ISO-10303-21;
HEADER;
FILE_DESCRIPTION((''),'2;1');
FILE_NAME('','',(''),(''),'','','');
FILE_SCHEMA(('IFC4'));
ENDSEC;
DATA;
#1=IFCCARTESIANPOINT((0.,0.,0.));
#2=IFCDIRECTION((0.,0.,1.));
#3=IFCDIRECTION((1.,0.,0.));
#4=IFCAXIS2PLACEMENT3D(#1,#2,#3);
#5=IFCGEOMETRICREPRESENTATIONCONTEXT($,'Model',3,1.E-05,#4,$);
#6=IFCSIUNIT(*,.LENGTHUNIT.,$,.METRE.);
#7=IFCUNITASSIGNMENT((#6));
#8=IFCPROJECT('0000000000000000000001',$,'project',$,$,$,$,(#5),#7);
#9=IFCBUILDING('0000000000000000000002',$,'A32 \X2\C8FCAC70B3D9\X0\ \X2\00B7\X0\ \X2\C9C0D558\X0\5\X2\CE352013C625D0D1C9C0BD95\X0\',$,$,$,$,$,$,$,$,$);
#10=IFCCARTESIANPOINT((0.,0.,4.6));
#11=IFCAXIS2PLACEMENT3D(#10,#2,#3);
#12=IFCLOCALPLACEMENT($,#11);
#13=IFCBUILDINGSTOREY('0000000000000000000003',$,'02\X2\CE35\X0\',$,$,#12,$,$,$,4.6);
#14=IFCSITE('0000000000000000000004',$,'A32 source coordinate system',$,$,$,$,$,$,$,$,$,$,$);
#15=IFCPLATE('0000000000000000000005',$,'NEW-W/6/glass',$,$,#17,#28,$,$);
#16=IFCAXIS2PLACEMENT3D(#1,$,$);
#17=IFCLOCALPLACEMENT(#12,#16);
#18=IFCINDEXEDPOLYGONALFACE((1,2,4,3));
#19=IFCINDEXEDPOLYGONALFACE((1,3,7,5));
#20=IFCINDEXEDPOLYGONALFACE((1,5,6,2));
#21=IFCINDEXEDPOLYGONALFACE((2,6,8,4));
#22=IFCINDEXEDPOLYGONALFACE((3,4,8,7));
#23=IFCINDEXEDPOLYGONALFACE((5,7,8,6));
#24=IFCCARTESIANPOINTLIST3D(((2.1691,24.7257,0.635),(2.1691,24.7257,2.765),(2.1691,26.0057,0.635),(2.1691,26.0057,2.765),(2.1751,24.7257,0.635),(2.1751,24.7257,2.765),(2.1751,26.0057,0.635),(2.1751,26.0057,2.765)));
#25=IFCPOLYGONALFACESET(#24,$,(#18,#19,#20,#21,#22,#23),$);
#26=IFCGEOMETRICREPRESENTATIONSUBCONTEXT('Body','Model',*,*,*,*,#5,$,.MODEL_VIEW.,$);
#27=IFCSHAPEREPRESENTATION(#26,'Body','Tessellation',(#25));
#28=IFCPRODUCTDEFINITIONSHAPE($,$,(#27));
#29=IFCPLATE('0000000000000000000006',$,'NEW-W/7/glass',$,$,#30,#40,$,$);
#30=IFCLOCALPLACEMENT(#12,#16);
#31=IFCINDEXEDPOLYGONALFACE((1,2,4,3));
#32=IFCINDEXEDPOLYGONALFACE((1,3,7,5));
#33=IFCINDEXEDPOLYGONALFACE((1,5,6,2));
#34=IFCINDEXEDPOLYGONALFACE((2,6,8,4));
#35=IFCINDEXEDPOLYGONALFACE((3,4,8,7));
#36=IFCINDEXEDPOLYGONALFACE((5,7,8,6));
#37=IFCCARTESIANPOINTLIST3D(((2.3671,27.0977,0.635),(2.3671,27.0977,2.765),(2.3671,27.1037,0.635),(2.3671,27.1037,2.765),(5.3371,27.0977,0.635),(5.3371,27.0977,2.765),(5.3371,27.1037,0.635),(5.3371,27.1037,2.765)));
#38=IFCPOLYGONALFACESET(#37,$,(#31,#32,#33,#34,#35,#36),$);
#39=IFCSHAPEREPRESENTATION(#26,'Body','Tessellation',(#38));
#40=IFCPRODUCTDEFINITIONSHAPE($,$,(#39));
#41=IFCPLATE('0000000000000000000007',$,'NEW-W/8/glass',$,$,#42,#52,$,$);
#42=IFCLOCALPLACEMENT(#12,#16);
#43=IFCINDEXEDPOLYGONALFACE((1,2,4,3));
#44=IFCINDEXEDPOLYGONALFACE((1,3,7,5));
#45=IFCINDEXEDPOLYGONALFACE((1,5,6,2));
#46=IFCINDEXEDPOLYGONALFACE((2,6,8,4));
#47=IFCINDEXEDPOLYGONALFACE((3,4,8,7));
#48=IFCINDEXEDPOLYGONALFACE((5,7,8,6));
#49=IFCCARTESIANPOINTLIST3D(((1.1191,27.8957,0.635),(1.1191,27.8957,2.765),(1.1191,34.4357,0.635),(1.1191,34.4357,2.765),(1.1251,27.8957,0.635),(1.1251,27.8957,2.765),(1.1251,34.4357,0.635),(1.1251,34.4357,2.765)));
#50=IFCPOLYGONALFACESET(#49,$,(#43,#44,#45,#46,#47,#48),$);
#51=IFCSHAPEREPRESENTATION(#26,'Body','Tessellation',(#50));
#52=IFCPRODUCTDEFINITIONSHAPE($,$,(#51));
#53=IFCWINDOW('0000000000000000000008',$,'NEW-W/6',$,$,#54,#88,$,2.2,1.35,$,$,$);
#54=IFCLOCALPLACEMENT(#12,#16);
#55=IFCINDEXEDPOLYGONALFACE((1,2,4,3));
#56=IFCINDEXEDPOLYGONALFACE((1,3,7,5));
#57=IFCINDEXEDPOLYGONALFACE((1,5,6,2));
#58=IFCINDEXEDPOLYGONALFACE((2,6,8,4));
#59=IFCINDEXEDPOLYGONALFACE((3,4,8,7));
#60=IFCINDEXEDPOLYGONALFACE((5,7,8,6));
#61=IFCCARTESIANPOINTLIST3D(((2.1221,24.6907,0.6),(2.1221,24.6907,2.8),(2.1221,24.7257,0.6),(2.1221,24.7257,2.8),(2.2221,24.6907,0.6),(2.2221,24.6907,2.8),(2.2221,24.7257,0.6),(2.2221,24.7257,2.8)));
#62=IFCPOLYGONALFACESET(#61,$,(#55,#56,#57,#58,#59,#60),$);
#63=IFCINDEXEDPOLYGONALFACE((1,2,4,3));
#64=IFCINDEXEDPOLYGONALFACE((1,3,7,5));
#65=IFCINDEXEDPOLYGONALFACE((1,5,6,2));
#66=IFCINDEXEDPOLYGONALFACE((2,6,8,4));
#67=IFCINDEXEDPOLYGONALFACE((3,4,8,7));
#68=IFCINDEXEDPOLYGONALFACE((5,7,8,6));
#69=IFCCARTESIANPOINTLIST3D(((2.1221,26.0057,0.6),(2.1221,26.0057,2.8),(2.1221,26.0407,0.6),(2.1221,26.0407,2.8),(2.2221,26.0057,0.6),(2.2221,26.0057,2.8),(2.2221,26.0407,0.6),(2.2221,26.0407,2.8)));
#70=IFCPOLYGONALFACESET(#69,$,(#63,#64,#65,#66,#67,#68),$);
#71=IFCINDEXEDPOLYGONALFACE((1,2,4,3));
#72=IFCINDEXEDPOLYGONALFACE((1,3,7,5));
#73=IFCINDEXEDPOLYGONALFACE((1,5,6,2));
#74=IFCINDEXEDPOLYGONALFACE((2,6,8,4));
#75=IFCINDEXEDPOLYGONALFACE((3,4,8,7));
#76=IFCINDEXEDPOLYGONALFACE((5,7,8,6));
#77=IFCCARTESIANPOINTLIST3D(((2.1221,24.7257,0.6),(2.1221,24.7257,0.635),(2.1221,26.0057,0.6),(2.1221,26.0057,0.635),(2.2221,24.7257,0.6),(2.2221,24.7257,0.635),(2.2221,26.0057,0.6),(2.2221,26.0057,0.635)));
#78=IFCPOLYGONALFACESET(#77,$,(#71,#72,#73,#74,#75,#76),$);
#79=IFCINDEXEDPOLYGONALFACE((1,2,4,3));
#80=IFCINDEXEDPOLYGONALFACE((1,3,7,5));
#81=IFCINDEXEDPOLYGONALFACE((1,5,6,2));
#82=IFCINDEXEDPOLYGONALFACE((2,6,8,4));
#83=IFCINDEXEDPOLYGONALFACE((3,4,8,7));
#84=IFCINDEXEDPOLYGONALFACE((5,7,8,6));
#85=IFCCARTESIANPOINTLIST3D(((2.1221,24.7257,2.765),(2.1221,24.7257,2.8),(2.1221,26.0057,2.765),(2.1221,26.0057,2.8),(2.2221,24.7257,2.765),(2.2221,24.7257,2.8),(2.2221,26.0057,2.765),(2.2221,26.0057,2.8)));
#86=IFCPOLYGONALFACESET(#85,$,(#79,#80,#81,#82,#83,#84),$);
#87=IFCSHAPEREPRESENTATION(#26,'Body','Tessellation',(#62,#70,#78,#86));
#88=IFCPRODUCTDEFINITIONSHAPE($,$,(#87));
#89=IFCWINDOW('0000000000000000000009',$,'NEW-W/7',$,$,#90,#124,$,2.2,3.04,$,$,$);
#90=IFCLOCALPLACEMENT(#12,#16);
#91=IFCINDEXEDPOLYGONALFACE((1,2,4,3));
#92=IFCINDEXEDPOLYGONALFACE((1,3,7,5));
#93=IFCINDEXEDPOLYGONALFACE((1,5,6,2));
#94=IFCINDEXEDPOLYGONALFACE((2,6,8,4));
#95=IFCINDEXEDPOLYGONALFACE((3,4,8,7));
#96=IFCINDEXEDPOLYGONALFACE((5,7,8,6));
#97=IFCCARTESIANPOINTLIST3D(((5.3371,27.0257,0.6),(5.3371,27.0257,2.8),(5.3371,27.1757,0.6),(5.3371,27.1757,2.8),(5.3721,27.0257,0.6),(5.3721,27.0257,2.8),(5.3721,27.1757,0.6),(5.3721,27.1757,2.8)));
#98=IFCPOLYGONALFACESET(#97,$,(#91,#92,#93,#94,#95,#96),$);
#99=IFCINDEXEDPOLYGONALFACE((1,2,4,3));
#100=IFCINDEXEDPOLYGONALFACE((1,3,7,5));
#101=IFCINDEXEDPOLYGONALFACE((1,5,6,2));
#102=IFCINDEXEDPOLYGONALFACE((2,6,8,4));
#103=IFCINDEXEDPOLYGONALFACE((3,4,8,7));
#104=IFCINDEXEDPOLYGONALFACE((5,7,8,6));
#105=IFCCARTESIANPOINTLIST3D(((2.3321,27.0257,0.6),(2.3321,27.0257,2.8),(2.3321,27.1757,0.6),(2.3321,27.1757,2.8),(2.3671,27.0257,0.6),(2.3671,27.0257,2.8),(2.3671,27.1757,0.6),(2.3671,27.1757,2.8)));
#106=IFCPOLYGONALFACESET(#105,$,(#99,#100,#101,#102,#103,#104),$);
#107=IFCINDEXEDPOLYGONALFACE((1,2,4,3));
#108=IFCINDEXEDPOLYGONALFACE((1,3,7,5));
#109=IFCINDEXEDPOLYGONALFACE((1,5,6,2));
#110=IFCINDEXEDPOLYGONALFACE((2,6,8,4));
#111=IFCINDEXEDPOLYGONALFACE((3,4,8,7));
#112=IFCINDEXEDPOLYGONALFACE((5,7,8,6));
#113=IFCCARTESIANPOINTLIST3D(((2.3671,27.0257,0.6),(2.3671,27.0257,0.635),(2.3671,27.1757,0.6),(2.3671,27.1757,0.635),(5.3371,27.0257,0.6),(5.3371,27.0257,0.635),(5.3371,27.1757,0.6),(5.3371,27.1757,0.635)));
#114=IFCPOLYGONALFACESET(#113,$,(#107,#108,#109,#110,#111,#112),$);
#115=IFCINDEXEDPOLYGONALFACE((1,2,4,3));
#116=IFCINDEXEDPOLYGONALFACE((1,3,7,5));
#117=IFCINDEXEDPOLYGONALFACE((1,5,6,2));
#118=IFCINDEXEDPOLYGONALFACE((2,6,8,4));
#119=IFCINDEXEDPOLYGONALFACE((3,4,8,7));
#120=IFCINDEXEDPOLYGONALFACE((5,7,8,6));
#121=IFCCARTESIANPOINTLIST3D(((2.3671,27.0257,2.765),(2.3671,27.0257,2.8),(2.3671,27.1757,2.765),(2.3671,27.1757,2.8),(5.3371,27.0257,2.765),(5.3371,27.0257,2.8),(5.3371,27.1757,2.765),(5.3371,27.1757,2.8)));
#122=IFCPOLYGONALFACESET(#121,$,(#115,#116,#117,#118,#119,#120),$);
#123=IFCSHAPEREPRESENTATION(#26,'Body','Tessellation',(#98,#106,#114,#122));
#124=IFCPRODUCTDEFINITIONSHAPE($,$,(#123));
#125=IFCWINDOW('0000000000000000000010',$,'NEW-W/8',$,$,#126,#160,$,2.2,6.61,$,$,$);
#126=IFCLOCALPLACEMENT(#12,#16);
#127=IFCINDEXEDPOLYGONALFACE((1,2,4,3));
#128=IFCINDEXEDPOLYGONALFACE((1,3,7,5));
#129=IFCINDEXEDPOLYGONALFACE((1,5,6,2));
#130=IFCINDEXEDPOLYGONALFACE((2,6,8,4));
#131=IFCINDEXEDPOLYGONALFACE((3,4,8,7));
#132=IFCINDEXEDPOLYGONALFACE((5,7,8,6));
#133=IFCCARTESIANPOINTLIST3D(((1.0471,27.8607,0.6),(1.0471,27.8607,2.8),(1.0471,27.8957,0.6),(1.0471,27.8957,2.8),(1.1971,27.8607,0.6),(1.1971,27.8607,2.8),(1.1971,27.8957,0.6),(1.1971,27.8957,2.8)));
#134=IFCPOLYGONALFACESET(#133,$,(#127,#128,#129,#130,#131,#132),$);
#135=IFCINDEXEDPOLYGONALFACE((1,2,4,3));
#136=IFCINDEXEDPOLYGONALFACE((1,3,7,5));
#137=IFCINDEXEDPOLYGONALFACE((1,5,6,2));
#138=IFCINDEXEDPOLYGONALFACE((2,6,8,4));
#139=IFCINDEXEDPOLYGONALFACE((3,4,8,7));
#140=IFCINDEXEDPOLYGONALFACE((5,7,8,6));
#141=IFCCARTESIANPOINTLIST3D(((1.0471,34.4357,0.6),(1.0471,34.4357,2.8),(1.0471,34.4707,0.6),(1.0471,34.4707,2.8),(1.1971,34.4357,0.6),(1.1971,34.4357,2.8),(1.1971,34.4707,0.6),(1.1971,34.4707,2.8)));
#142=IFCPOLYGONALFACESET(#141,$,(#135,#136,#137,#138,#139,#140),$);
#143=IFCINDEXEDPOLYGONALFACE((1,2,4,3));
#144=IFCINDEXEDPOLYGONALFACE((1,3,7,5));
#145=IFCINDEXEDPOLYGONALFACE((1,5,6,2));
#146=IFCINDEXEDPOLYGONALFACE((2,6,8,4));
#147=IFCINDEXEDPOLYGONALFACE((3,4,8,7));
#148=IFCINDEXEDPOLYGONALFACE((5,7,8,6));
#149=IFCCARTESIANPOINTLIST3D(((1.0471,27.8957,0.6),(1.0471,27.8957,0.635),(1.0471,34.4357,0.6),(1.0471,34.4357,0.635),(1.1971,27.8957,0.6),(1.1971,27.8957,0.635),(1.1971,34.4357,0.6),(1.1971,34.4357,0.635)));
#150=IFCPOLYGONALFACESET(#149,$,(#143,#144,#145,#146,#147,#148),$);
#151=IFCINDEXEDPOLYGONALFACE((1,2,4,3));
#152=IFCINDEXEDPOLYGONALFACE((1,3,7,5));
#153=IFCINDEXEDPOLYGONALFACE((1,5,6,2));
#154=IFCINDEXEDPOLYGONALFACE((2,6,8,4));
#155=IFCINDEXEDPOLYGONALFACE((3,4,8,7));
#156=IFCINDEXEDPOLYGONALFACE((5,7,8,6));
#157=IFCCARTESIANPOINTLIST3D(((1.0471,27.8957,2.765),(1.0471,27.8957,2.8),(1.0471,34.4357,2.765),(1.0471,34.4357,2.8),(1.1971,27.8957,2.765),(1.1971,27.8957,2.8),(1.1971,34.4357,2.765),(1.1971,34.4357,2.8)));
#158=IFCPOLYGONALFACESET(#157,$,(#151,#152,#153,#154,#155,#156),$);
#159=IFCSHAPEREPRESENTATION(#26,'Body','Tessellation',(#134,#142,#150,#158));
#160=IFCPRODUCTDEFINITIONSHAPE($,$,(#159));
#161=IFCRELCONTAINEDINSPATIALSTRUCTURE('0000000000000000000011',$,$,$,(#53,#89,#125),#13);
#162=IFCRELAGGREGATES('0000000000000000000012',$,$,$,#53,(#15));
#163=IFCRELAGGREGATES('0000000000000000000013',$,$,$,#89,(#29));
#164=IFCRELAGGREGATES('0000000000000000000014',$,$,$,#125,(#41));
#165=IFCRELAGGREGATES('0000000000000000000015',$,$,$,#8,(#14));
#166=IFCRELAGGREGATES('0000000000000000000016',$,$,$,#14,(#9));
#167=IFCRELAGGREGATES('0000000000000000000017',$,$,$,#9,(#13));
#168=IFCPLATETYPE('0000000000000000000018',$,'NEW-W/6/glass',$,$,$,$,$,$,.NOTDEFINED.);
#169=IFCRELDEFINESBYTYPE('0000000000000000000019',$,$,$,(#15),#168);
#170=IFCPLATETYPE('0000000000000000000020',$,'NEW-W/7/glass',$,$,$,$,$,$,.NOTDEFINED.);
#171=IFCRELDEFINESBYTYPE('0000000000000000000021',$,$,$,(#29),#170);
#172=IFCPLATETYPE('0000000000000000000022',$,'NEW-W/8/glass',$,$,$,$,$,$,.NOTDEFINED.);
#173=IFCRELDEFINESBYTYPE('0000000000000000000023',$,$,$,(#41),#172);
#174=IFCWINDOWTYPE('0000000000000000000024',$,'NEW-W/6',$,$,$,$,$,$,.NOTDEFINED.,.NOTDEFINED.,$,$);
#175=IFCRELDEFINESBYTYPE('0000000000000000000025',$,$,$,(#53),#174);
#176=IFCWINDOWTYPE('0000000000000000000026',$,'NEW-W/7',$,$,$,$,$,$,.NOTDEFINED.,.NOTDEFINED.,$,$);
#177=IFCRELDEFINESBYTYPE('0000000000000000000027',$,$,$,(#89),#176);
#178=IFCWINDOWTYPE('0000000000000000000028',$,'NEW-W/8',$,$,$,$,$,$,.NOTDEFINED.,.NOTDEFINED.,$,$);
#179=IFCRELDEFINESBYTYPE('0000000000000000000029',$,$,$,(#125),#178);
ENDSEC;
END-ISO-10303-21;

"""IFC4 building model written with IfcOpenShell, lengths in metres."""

from ifc_helpers import new_model, si_unit, frame, origin, origin_with_axes, place, context, subcontext, project, spatial, polyline, outline, extrude, source, transform, mapped, type_object, type_shapes, element, aggregate, save


model = new_model("IFC4")

# Units and contexts
model_context = context("Model", 3, precision=1e-05, world=origin_with_axes())
body_context = subcontext(model_context, "Body", "Model", "MODEL_VIEW")
ifc_project = project(units=[si_unit("LENGTHUNIT", "METRE")], contexts=[model_context])

# Plates
plate_type_1 = type_object("IfcPlateType", Name="NEW-W/6/glass", PredefinedType="NOTDEFINED")
shared_shape_1 = source(origin(), body_context, "Body", "SweptSolid", [
    extrude(outline(polyline([(2.1751, 24.7257), (2.1691, 24.7257), (2.1691, 26.0057), (2.1751, 26.0057), (2.1751, 24.7257)])), frame((0.0, 0.0, 0.635)), (0.0, 0.0, 1.0), 2.13),
])
type_shapes(plate_type_1, [shared_shape_1])
storey_placement = place(None, frame((0.0, 0.0, 4.6), z_axis=(0.0, 0.0, 1.0), x_axis=(1.0, 0.0, 0.0)))
window_1_placement = place(storey_placement, origin_with_axes())
plate_1_placement = place(window_1_placement, origin_with_axes())
plate_1 = element("IfcPlate", 1, at=plate_1_placement, type_object=plate_type_1, Name="NEW-W/6/glass", context=body_context, shape_type="MappedRepresentation", body=[
    mapped(shared_shape_1, transform((0.0, 0.0, 0.0), scale=1.0)),
])
plate_type_2 = type_object("IfcPlateType", Name="NEW-W/7/glass", PredefinedType="NOTDEFINED")
shared_shape_2 = source(origin(), body_context, "Body", "SweptSolid", [
    extrude(outline(polyline([(5.3371, 27.0977), (2.3671, 27.0977), (2.3671, 27.1037), (5.3371, 27.1037), (5.3371, 27.0977)])), frame((0.0, 0.0, 0.635)), (0.0, 0.0, 1.0), 2.13),
])
type_shapes(plate_type_2, [shared_shape_2])
window_2_placement = place(storey_placement, origin_with_axes())
plate_2_placement = place(window_2_placement, origin_with_axes())
plate_2 = element("IfcPlate", 2, at=plate_2_placement, type_object=plate_type_2, Name="NEW-W/7/glass", context=body_context, shape_type="MappedRepresentation", body=[
    mapped(shared_shape_2, transform((0.0, 0.0, 0.0), scale=1.0)),
])
plate_type_3 = type_object("IfcPlateType", Name="NEW-W/8/glass", PredefinedType="NOTDEFINED")
shared_shape_3 = source(origin(), body_context, "Body", "SweptSolid", [
    extrude(outline(polyline([(1.1251, 27.8957), (1.1191, 27.8957), (1.1191, 34.4357), (1.1251, 34.4357), (1.1251, 27.8957)])), frame((0.0, 0.0, 0.635)), (0.0, 0.0, 1.0), 2.13),
])
type_shapes(plate_type_3, [shared_shape_3])
window_3_placement = place(storey_placement, origin_with_axes())
plate_3_placement = place(window_3_placement, origin_with_axes())
plate_3 = element("IfcPlate", 3, at=plate_3_placement, type_object=plate_type_3, Name="NEW-W/8/glass", context=body_context, shape_type="MappedRepresentation", body=[
    mapped(shared_shape_3, transform((0.0, 0.0, 0.0), scale=1.0)),
])

# Site, building, storey
site = spatial("IfcSite", under=ifc_project, Name="A32 source coordinate system")
building = spatial("IfcBuilding", under=site, Name="A32 주거동 · 지하5층–옥탑지붕")
storey = spatial("IfcBuildingStorey", under=building, at=storey_placement, Name="02층", Elevation=4.6)

# Windows
window_type_1 = type_object("IfcWindowType", Name="NEW-W/6", PartitioningType="NOTDEFINED", PredefinedType="NOTDEFINED")
shared_shape_4 = source(origin(), body_context, "Body", "SweptSolid", [
    extrude(outline(polyline([(2.1221, 24.6907), (2.1221, 24.7257), (2.2221, 24.7257), (2.2221, 24.6907), (2.1221, 24.6907)])), frame((0.0, 0.0, 0.6)), (0.0, 0.0, 1.0), 2.2),
    extrude(outline(polyline([(2.1221, 26.0057), (2.1221, 26.0407), (2.2221, 26.0407), (2.2221, 26.0057), (2.1221, 26.0057)])), frame((0.0, 0.0, 0.6)), (0.0, 0.0, 1.0), 2.2),
    extrude(outline(polyline([(2.2221, 24.7257), (2.2221, 26.0057), (2.1221, 26.0057), (2.1221, 24.7257), (2.2221, 24.7257)])), frame((0.0, 0.0, 0.6)), (0.0, 0.0, 1.0), 0.035),
    extrude(outline(polyline([(2.2221, 24.7257), (2.2221, 26.0057), (2.1221, 26.0057), (2.1221, 24.7257), (2.2221, 24.7257)])), frame((0.0, 0.0, 2.765)), (0.0, 0.0, 1.0), 0.035),
])
type_shapes(window_type_1, [shared_shape_4])
window_1 = element("IfcWindow", 4, at=window_1_placement, inside=storey, type_object=window_type_1, Name="NEW-W/6", OverallHeight=2.2, OverallWidth=1.35, context=body_context, shape_type="MappedRepresentation", body=[
    mapped(shared_shape_4, transform((0.0, 0.0, 0.0), scale=1.0)),
])
aggregate(window_1, [plate_1])
window_type_2 = type_object("IfcWindowType", Name="NEW-W/7", PartitioningType="NOTDEFINED", PredefinedType="NOTDEFINED")
shared_shape_5 = source(origin(), body_context, "Body", "SweptSolid", [
    extrude(outline(polyline([(5.3371, 27.0257), (5.3371, 27.1757), (5.3721, 27.1757), (5.3721, 27.0257), (5.3371, 27.0257)])), frame((0.0, 0.0, 0.6)), (0.0, 0.0, 1.0), 2.2),
    extrude(outline(polyline([(2.3321, 27.0257), (2.3321, 27.1757), (2.3671, 27.1757), (2.3671, 27.0257), (2.3321, 27.0257)])), frame((0.0, 0.0, 0.6)), (0.0, 0.0, 1.0), 2.2),
    extrude(outline(polyline([(5.3371, 27.0257), (5.3371, 27.1757), (2.3671, 27.1757), (2.3671, 27.0257), (5.3371, 27.0257)])), frame((0.0, 0.0, 0.6)), (0.0, 0.0, 1.0), 0.035),
    extrude(outline(polyline([(5.3371, 27.0257), (5.3371, 27.1757), (2.3671, 27.1757), (2.3671, 27.0257), (5.3371, 27.0257)])), frame((0.0, 0.0, 2.765)), (0.0, 0.0, 1.0), 0.035),
])
type_shapes(window_type_2, [shared_shape_5])
window_2 = element("IfcWindow", 5, at=window_2_placement, inside=storey, type_object=window_type_2, Name="NEW-W/7", OverallHeight=2.2, OverallWidth=3.04, context=body_context, shape_type="MappedRepresentation", body=[
    mapped(shared_shape_5, transform((0.0, 0.0, 0.0), scale=1.0)),
])
aggregate(window_2, [plate_2])
window_type_3 = type_object("IfcWindowType", Name="NEW-W/8", PartitioningType="NOTDEFINED", PredefinedType="NOTDEFINED")
shared_shape_6 = source(origin(), body_context, "Body", "SweptSolid", [
    extrude(outline(polyline([(1.0471, 27.8607), (1.0471, 27.8957), (1.1971, 27.8957), (1.1971, 27.8607), (1.0471, 27.8607)])), frame((0.0, 0.0, 0.6)), (0.0, 0.0, 1.0), 2.2),
    extrude(outline(polyline([(1.0471, 34.4357), (1.0471, 34.4707), (1.1971, 34.4707), (1.1971, 34.4357), (1.0471, 34.4357)])), frame((0.0, 0.0, 0.6)), (0.0, 0.0, 1.0), 2.2),
    extrude(outline(polyline([(1.1971, 27.8957), (1.1971, 34.4357), (1.0471, 34.4357), (1.0471, 27.8957), (1.1971, 27.8957)])), frame((0.0, 0.0, 0.6)), (0.0, 0.0, 1.0), 0.035),
    extrude(outline(polyline([(1.1971, 27.8957), (1.1971, 34.4357), (1.0471, 34.4357), (1.0471, 27.8957), (1.1971, 27.8957)])), frame((0.0, 0.0, 2.765)), (0.0, 0.0, 1.0), 0.035),
])
type_shapes(window_type_3, [shared_shape_6])
window_3 = element("IfcWindow", 6, at=window_3_placement, inside=storey, type_object=window_type_3, Name="NEW-W/8", OverallHeight=2.2, OverallWidth=6.61, context=body_context, shape_type="MappedRepresentation", body=[
    mapped(shared_shape_6, transform((0.0, 0.0, 0.0), scale=1.0)),
])
aggregate(window_3, [plate_3])

save(model, "model.ifc")
